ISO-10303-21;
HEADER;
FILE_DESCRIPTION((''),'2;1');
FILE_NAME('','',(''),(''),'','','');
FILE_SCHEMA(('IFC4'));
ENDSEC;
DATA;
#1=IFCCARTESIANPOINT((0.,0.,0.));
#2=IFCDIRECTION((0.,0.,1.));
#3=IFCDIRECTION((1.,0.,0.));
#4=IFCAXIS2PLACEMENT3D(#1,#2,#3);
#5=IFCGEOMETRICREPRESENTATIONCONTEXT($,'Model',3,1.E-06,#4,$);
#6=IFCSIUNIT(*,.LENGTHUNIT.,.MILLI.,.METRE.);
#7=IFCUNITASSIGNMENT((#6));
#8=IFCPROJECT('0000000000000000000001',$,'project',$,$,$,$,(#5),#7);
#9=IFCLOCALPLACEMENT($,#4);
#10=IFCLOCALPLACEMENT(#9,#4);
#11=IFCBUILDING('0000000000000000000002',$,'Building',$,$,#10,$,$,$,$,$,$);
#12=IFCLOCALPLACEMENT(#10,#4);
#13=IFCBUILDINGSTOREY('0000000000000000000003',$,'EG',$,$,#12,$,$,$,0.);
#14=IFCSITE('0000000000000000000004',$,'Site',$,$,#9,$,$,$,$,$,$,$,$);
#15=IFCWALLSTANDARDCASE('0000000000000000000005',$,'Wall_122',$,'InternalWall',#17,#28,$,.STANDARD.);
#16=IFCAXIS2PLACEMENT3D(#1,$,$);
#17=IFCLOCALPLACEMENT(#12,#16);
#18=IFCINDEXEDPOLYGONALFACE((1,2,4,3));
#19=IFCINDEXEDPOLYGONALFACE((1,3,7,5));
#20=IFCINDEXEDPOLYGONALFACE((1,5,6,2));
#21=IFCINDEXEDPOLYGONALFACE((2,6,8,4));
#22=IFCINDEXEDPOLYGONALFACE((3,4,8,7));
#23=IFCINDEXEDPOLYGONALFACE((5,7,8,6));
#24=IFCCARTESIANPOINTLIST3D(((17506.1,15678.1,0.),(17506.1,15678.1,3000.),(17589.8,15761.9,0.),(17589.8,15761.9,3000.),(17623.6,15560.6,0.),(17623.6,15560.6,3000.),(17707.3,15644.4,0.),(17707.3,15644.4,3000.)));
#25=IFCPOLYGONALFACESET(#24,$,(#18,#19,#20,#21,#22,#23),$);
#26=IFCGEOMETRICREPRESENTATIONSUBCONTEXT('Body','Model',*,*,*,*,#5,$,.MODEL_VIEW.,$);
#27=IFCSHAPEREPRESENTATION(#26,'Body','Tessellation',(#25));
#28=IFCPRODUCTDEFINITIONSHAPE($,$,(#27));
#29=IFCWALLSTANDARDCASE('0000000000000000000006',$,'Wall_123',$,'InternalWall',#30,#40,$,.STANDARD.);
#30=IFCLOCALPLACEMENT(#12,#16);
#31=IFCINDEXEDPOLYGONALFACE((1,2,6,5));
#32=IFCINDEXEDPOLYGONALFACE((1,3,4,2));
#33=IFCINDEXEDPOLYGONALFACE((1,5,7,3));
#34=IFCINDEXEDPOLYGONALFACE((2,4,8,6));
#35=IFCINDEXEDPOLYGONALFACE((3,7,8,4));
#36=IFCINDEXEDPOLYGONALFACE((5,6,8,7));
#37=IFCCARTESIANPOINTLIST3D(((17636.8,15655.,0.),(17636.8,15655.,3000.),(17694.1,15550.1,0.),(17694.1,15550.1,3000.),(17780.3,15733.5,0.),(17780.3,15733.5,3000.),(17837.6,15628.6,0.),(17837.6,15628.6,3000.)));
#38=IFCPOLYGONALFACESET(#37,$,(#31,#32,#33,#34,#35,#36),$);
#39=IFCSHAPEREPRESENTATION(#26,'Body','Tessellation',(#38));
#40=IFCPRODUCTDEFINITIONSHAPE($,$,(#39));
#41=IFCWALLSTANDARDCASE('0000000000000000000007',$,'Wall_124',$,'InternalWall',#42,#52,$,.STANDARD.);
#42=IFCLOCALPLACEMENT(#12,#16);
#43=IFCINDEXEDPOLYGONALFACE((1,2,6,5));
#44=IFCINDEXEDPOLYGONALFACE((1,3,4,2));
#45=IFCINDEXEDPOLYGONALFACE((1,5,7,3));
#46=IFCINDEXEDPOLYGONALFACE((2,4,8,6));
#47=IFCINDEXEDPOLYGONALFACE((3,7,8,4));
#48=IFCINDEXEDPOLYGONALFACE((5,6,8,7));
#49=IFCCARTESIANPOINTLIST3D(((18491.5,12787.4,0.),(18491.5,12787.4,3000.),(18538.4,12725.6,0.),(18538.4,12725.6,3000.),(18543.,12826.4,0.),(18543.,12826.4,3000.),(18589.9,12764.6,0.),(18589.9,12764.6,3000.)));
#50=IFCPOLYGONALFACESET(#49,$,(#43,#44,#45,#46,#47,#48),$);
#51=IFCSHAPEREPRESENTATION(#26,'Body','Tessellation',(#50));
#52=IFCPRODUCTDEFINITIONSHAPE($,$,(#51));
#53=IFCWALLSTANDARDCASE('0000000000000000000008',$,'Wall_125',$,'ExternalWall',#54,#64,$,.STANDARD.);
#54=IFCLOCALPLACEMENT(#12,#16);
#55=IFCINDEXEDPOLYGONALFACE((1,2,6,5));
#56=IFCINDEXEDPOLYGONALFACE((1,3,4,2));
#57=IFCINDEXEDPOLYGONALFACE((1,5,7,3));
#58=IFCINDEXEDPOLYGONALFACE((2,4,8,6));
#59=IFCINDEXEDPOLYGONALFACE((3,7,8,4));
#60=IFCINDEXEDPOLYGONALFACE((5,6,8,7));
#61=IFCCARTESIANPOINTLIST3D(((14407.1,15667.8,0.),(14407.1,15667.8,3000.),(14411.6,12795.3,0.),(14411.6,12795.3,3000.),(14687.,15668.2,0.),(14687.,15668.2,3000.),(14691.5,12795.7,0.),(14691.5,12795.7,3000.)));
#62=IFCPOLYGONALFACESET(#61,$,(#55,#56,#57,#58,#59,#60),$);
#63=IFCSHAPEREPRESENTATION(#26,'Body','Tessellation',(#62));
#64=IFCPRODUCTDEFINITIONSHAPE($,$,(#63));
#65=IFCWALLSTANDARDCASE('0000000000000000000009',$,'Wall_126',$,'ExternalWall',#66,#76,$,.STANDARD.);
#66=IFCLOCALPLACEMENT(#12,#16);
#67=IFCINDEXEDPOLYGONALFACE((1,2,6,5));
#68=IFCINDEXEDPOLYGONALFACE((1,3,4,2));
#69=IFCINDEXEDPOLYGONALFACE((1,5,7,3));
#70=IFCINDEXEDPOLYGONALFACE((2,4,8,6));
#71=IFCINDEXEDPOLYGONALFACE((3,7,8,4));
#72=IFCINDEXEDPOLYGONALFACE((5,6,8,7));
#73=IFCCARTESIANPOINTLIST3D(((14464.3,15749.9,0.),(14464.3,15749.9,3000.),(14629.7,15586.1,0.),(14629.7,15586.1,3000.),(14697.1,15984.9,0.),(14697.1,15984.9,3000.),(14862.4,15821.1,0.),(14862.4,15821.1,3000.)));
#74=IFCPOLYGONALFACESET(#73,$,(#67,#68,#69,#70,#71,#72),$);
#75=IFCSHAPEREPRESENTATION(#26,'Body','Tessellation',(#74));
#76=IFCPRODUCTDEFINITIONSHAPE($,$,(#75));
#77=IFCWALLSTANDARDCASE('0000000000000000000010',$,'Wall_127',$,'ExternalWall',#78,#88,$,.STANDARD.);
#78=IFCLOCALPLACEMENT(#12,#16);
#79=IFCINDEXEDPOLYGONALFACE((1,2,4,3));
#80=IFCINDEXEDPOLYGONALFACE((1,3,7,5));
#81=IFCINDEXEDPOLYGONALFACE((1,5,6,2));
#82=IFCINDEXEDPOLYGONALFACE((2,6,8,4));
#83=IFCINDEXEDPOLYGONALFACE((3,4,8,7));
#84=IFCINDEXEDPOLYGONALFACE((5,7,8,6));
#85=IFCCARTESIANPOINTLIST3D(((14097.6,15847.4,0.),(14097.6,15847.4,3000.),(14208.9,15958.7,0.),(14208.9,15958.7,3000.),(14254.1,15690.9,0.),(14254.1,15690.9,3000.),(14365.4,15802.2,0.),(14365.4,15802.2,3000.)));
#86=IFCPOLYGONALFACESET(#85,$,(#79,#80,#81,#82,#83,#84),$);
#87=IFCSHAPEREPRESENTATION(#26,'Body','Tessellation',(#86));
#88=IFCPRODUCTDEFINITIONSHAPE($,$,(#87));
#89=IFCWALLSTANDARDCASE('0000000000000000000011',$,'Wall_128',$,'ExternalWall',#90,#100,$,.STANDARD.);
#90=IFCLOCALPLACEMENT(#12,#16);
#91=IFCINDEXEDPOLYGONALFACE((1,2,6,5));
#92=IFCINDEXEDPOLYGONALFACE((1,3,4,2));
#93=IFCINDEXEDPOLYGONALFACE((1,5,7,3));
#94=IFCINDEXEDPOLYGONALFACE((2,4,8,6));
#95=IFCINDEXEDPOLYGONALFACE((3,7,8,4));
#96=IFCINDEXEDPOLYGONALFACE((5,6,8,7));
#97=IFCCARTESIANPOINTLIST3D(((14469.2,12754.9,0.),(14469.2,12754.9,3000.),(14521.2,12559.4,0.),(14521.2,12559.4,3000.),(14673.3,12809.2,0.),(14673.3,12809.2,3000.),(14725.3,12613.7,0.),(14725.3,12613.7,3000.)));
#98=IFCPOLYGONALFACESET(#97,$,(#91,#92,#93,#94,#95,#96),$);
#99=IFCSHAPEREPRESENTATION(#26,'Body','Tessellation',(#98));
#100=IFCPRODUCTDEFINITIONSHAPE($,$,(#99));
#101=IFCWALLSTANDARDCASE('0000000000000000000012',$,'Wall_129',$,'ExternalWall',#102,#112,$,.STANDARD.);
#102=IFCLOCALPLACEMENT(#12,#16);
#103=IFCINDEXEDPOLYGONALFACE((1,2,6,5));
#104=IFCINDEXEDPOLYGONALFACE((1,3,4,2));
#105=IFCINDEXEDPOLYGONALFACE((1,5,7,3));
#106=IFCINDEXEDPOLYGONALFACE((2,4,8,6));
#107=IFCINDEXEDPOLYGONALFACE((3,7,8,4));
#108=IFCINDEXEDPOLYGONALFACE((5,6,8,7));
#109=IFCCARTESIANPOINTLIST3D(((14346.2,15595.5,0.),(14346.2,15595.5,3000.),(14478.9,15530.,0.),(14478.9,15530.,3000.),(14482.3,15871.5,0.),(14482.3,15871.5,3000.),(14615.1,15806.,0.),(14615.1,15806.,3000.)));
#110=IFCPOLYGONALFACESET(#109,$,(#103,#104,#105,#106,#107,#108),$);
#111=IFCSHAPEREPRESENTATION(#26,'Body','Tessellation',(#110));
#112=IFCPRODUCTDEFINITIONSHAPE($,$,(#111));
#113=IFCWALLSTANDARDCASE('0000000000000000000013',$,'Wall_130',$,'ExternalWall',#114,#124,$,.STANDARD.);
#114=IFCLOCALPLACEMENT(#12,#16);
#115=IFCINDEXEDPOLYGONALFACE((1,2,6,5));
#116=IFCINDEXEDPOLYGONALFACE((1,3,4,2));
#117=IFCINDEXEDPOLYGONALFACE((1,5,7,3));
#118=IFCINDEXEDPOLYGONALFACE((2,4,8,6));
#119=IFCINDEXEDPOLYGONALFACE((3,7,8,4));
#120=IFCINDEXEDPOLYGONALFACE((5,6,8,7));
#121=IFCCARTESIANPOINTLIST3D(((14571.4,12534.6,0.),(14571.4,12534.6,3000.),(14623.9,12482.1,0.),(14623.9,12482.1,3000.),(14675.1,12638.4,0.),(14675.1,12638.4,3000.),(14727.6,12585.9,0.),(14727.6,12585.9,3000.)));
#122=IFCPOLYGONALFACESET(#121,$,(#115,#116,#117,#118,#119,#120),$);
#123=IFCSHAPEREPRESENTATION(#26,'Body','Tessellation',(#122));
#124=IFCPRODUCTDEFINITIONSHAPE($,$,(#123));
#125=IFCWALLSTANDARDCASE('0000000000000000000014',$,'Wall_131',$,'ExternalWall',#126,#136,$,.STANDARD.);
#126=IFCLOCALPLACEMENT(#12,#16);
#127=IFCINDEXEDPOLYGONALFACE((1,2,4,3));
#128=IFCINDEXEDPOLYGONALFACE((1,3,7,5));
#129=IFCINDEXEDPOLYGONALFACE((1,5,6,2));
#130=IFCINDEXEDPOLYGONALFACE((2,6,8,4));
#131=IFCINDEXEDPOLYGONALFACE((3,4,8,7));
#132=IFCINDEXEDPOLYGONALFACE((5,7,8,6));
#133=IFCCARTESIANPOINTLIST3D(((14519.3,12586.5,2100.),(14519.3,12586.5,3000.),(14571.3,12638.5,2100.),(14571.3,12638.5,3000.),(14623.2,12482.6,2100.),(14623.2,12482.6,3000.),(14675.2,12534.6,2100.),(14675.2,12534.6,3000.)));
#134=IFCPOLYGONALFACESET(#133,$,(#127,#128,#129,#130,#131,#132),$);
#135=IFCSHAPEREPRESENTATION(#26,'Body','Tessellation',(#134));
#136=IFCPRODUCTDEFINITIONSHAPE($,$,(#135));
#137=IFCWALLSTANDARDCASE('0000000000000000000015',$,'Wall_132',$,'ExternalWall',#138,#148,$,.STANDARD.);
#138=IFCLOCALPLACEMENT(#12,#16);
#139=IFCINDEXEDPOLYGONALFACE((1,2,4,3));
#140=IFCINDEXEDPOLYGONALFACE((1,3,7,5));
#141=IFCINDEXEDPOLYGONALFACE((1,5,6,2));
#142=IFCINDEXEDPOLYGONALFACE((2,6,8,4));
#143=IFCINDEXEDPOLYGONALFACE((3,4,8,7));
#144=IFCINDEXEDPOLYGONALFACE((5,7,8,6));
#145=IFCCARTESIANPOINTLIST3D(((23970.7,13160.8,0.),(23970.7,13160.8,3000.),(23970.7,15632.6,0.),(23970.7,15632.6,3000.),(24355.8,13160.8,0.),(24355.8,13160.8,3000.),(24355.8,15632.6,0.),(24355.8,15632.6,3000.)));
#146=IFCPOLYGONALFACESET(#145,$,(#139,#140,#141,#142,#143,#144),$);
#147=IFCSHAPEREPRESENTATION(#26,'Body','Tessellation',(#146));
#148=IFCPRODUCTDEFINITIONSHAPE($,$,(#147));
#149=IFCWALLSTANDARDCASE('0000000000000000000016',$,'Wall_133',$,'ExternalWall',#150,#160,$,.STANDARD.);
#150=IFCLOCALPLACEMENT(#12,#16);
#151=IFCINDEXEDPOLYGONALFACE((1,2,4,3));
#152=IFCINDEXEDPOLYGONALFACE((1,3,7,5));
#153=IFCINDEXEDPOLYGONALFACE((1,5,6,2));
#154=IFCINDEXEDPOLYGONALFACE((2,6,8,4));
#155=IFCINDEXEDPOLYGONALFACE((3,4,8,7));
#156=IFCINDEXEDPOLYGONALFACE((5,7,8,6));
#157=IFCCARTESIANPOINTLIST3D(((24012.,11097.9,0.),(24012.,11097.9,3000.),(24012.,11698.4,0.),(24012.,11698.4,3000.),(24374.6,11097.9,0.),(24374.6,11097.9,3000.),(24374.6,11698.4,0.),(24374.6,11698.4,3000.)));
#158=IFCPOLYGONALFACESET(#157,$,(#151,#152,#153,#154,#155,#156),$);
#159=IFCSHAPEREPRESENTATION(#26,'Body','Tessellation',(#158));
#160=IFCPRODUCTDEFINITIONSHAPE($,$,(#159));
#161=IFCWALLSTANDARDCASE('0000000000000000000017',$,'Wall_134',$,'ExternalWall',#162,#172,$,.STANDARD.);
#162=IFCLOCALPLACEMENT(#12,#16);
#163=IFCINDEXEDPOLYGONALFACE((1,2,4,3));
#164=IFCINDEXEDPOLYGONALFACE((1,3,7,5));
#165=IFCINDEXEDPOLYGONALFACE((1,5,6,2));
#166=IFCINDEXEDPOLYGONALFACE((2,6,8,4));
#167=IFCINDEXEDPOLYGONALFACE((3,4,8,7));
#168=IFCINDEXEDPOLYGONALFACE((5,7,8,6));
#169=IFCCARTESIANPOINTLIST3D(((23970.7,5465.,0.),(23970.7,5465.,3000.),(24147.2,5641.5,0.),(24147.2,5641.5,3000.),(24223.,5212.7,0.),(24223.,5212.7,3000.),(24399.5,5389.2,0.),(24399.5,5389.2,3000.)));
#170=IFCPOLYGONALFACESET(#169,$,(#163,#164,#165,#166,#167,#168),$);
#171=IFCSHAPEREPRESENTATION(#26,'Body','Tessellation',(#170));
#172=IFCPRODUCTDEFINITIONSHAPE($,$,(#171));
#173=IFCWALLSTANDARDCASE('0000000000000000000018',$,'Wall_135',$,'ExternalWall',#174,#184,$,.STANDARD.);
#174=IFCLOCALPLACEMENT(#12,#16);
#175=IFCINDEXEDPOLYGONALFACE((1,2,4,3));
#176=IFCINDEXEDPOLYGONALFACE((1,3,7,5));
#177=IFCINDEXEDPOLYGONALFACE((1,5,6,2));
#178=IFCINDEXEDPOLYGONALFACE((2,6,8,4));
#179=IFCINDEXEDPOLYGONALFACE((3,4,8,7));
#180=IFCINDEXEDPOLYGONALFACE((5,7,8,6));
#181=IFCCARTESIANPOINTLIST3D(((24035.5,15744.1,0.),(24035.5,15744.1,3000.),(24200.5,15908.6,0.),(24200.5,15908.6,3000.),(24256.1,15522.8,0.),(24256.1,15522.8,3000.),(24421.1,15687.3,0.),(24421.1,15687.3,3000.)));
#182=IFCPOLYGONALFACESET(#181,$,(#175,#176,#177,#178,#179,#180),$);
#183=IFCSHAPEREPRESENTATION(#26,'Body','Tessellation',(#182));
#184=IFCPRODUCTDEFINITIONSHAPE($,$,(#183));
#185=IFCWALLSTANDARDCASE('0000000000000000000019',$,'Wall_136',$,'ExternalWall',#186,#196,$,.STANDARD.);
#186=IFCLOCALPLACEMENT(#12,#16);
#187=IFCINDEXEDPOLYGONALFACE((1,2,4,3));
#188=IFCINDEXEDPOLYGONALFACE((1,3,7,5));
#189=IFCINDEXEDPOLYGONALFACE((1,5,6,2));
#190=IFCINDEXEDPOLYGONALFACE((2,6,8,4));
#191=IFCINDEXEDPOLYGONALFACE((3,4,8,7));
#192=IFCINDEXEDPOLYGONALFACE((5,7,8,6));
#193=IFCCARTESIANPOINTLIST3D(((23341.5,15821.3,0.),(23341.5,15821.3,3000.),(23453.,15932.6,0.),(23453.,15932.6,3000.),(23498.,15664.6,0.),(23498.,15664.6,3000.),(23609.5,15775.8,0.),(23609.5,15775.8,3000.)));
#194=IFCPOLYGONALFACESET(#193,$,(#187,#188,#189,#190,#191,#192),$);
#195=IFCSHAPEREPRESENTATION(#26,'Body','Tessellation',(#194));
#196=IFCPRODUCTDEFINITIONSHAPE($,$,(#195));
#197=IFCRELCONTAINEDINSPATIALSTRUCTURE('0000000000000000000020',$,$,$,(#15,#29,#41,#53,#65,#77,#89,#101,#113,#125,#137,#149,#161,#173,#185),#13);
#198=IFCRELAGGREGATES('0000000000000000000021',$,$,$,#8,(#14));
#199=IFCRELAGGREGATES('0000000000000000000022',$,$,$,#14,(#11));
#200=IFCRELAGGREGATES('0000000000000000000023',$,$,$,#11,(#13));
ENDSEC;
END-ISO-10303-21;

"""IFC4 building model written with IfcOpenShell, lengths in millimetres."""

from ifc_helpers import new_model, si_unit, frame, origin_with_axes, place, context, subcontext, project, spatial, rectangle, extrude, element, save


model = new_model("IFC4")

# Units and contexts
model_context = context("Model", 3, precision=1e-06, world=origin_with_axes())
body_context = subcontext(model_context, "Body", "Model", "MODEL_VIEW")
ifc_project = project(units=[si_unit("LENGTHUNIT", "METRE", prefix="MILLI")], contexts=[model_context])

# Site, building, storey
site_placement = place(None, origin_with_axes())
site = spatial("IfcSite", under=ifc_project, at=site_placement, Name="Site")
building_placement = place(site_placement, origin_with_axes())
building = spatial("IfcBuilding", under=site, at=building_placement, Name="Building")
storey_placement = place(building_placement, origin_with_axes())
storey = spatial("IfcBuildingStorey", under=building, at=storey_placement, Name="EG", Elevation=0.0)

# Walls
wall_1_placement = place(storey_placement, origin_with_axes())
element("IfcWallStandardCase", 1, at=wall_1_placement, inside=storey, Name="Wall_122", ObjectType="InternalWall", PredefinedType="STANDARD", context=body_context, shape_type="SweptSolid", body=[
    extrude(rectangle(XDim=166.2, YDim=118.5), frame((17606.7, 15661.3, 0.0), z_axis=(0.0, 0.0, 1.0), x_axis=(-0.707107, 0.707107, 0.0)), (0.0, 0.0, 1.0), 3000.0),
])
wall_2_placement = place(storey_placement, origin_with_axes())
element("IfcWallStandardCase", 2, at=wall_2_placement, inside=storey, Name="Wall_123", ObjectType="InternalWall", PredefinedType="STANDARD", context=body_context, shape_type="SweptSolid", body=[
    extrude(rectangle(XDim=163.6, YDim=119.5), frame((17737.2, 15641.8, 0.0), z_axis=(0.0, 0.0, 1.0), x_axis=(-0.877311, -0.479923, 0.0)), (0.0, 0.0, 1.0), 3000.0),
])
wall_3_placement = place(storey_placement, origin_with_axes())
element("IfcWallStandardCase", 3, at=wall_3_placement, inside=storey, Name="Wall_124", ObjectType="InternalWall", PredefinedType="STANDARD", context=body_context, shape_type="SweptSolid", body=[
    extrude(rectangle(XDim=64.6, YDim=77.5), frame((18540.7, 12776.0, 0.0), z_axis=(0.0, 0.0, 1.0), x_axis=(0.797205, 0.603709, 0.0)), (0.0, 0.0, 1.0), 3000.0),
])
wall_4_placement = place(storey_placement, origin_with_axes())
element("IfcWallStandardCase", 4, at=wall_4_placement, inside=storey, Name="Wall_125", ObjectType="ExternalWall", PredefinedType="STANDARD", context=body_context, shape_type="SweptSolid", body=[
    extrude(rectangle(XDim=2872.5, YDim=279.9), frame((14549.3, 14231.8, 0.0), z_axis=(0.0, 0.0, 1.0), x_axis=(0.001567, -0.999999, 0.0)), (0.0, 0.0, 1.0), 3000.0),
])
wall_5_placement = place(storey_placement, origin_with_axes())
element("IfcWallStandardCase", 5, at=wall_5_placement, inside=storey, Name="Wall_126", ObjectType="ExternalWall", PredefinedType="STANDARD", context=body_context, shape_type="SweptSolid", body=[
    extrude(rectangle(XDim=330.7, YDim=232.8), frame((14663.4, 15785.5, 0.0), z_axis=(0.0, 0.0, 1.0), x_axis=(0.703705, 0.710492, 0.0)), (0.0, 0.0, 1.0), 3000.0),
])
wall_6_placement = place(storey_placement, origin_with_axes())
element("IfcWallStandardCase", 6, at=wall_6_placement, inside=storey, Name="Wall_127", ObjectType="ExternalWall", PredefinedType="STANDARD", context=body_context, shape_type="SweptSolid", body=[
    extrude(rectangle(XDim=221.3, YDim=157.4), frame((14231.5, 15824.8, 0.0), z_axis=(0.0, 0.0, 1.0), x_axis=(-0.707107, 0.707107, 0.0)), (0.0, 0.0, 1.0), 3000.0),
])
wall_7_placement = place(storey_placement, origin_with_axes())
element("IfcWallStandardCase", 7, at=wall_7_placement, inside=storey, Name="Wall_128", ObjectType="ExternalWall", PredefinedType="STANDARD", context=body_context, shape_type="SweptSolid", body=[
    extrude(rectangle(XDim=202.3, YDim=211.2), frame((14597.3, 12684.3, 0.0), z_axis=(0.0, 0.0, 1.0), x_axis=(0.257047, -0.966399, 0.0)), (0.0, 0.0, 1.0), 3000.0),
])
wall_8_placement = place(storey_placement, origin_with_axes())
element("IfcWallStandardCase", 8, at=wall_8_placement, inside=storey, Name="Wall_129", ObjectType="ExternalWall", PredefinedType="STANDARD", context=body_context, shape_type="SweptSolid", body=[
    extrude(rectangle(XDim=148.0, YDim=307.8), frame((14480.6, 15700.8, 0.0), z_axis=(0.0, 0.0, 1.0), x_axis=(-0.896793, 0.44245, 0.0)), (0.0, 0.0, 1.0), 3000.0),
])
wall_9_placement = place(storey_placement, origin_with_axes())
element("IfcWallStandardCase", 9, at=wall_9_placement, inside=storey, Name="Wall_130", ObjectType="ExternalWall", PredefinedType="STANDARD", context=body_context, shape_type="SweptSolid", body=[
    extrude(rectangle(XDim=74.2, YDim=146.8), frame((14649.5, 12560.3, 0.0), z_axis=(0.0, 0.0, 1.0), x_axis=(0.707107, -0.707107, 0.0)), (0.0, 0.0, 1.0), 3000.0),
])

# Wall, opening
wall_10_placement = place(storey_placement, origin_with_axes())
wall_10 = element("IfcWallStandardCase", 10, at=wall_10_placement, inside=storey, Name="Wall_131", ObjectType="ExternalWall", PredefinedType="STANDARD", context=body_context, shape_type="SweptSolid", body=[
    extrude(rectangle(XDim=73.5, YDim=146.9), frame((14597.3, 12560.5, 0.0), z_axis=(0.0, 0.0, 1.0), x_axis=(-0.707107, -0.707107, 0.0)), (0.0, 0.0, 1.0), 3000.0),
])
opening_1_placement = place(wall_10_placement, origin_with_axes())
element("IfcOpeningElement", 11, at=opening_1_placement, inside=storey, cuts=wall_10, context=body_context, shape_type="SweptSolid", body=[
    extrude(rectangle(XDim=450.0, YDim=146.9), frame((14597.3, 12560.5, 0.0), z_axis=(0.0, 0.0, 1.0), x_axis=(-0.707107, -0.707107, 0.0)), (0.0, 0.0, 1.0), 2100.0),
])

# Walls
wall_11_placement = place(storey_placement, origin_with_axes())
element("IfcWallStandardCase", 12, at=wall_11_placement, inside=storey, Name="Wall_132", ObjectType="ExternalWall", PredefinedType="STANDARD", context=body_context, shape_type="SweptSolid", body=[
    extrude(rectangle(XDim=2471.7, YDim=385.1), frame((24163.3, 14396.7, 0.0), z_axis=(0.0, 0.0, 1.0), x_axis=(0.0, -1.0, 0.0)), (0.0, 0.0, 1.0), 3000.0),
])
wall_12_placement = place(storey_placement, origin_with_axes())
element("IfcWallStandardCase", 13, at=wall_12_placement, inside=storey, Name="Wall_133", ObjectType="ExternalWall", PredefinedType="STANDARD", context=body_context, shape_type="SweptSolid", body=[
    extrude(rectangle(XDim=600.5, YDim=362.6), frame((24193.3, 11398.2, 0.0), z_axis=(0.0, 0.0, 1.0), x_axis=(0.0, -1.0, 0.0)), (0.0, 0.0, 1.0), 3000.0),
])
wall_13_placement = place(storey_placement, origin_with_axes())
element("IfcWallStandardCase", 14, at=wall_13_placement, inside=storey, Name="Wall_134", ObjectType="ExternalWall", PredefinedType="STANDARD", context=body_context, shape_type="SweptSolid", body=[
    extrude(rectangle(XDim=356.9, YDim=249.7), frame((24185.1, 5427.1, 0.0), z_axis=(0.0, 0.0, 1.0), x_axis=(0.707107, -0.707107, 0.0)), (0.0, 0.0, 1.0), 3000.0),
])
wall_14_placement = place(storey_placement, origin_with_axes())
element("IfcWallStandardCase", 15, at=wall_14_placement, inside=storey, Name="Wall_135", ObjectType="ExternalWall", PredefinedType="STANDARD", context=body_context, shape_type="SweptSolid", body=[
    extrude(rectangle(XDim=233.0, YDim=312.4), frame((24228.3, 15715.7, 0.0), z_axis=(0.0, 0.0, 1.0), x_axis=(0.708179, 0.706033, 0.0)), (0.0, 0.0, 1.0), 3000.0),
])
wall_15_placement = place(storey_placement, origin_with_axes())
element("IfcWallStandardCase", 16, at=wall_15_placement, inside=storey, Name="Wall_136", ObjectType="ExternalWall", PredefinedType="STANDARD", context=body_context, shape_type="SweptSolid", body=[
    extrude(rectangle(XDim=221.5, YDim=157.5), frame((23475.5, 15798.6, 0.0), z_axis=(0.0, 0.0, 1.0), x_axis=(-0.706542, 0.707671, 0.0)), (0.0, 0.0, 1.0), 3000.0),
])

save(model, "model.ifc")
